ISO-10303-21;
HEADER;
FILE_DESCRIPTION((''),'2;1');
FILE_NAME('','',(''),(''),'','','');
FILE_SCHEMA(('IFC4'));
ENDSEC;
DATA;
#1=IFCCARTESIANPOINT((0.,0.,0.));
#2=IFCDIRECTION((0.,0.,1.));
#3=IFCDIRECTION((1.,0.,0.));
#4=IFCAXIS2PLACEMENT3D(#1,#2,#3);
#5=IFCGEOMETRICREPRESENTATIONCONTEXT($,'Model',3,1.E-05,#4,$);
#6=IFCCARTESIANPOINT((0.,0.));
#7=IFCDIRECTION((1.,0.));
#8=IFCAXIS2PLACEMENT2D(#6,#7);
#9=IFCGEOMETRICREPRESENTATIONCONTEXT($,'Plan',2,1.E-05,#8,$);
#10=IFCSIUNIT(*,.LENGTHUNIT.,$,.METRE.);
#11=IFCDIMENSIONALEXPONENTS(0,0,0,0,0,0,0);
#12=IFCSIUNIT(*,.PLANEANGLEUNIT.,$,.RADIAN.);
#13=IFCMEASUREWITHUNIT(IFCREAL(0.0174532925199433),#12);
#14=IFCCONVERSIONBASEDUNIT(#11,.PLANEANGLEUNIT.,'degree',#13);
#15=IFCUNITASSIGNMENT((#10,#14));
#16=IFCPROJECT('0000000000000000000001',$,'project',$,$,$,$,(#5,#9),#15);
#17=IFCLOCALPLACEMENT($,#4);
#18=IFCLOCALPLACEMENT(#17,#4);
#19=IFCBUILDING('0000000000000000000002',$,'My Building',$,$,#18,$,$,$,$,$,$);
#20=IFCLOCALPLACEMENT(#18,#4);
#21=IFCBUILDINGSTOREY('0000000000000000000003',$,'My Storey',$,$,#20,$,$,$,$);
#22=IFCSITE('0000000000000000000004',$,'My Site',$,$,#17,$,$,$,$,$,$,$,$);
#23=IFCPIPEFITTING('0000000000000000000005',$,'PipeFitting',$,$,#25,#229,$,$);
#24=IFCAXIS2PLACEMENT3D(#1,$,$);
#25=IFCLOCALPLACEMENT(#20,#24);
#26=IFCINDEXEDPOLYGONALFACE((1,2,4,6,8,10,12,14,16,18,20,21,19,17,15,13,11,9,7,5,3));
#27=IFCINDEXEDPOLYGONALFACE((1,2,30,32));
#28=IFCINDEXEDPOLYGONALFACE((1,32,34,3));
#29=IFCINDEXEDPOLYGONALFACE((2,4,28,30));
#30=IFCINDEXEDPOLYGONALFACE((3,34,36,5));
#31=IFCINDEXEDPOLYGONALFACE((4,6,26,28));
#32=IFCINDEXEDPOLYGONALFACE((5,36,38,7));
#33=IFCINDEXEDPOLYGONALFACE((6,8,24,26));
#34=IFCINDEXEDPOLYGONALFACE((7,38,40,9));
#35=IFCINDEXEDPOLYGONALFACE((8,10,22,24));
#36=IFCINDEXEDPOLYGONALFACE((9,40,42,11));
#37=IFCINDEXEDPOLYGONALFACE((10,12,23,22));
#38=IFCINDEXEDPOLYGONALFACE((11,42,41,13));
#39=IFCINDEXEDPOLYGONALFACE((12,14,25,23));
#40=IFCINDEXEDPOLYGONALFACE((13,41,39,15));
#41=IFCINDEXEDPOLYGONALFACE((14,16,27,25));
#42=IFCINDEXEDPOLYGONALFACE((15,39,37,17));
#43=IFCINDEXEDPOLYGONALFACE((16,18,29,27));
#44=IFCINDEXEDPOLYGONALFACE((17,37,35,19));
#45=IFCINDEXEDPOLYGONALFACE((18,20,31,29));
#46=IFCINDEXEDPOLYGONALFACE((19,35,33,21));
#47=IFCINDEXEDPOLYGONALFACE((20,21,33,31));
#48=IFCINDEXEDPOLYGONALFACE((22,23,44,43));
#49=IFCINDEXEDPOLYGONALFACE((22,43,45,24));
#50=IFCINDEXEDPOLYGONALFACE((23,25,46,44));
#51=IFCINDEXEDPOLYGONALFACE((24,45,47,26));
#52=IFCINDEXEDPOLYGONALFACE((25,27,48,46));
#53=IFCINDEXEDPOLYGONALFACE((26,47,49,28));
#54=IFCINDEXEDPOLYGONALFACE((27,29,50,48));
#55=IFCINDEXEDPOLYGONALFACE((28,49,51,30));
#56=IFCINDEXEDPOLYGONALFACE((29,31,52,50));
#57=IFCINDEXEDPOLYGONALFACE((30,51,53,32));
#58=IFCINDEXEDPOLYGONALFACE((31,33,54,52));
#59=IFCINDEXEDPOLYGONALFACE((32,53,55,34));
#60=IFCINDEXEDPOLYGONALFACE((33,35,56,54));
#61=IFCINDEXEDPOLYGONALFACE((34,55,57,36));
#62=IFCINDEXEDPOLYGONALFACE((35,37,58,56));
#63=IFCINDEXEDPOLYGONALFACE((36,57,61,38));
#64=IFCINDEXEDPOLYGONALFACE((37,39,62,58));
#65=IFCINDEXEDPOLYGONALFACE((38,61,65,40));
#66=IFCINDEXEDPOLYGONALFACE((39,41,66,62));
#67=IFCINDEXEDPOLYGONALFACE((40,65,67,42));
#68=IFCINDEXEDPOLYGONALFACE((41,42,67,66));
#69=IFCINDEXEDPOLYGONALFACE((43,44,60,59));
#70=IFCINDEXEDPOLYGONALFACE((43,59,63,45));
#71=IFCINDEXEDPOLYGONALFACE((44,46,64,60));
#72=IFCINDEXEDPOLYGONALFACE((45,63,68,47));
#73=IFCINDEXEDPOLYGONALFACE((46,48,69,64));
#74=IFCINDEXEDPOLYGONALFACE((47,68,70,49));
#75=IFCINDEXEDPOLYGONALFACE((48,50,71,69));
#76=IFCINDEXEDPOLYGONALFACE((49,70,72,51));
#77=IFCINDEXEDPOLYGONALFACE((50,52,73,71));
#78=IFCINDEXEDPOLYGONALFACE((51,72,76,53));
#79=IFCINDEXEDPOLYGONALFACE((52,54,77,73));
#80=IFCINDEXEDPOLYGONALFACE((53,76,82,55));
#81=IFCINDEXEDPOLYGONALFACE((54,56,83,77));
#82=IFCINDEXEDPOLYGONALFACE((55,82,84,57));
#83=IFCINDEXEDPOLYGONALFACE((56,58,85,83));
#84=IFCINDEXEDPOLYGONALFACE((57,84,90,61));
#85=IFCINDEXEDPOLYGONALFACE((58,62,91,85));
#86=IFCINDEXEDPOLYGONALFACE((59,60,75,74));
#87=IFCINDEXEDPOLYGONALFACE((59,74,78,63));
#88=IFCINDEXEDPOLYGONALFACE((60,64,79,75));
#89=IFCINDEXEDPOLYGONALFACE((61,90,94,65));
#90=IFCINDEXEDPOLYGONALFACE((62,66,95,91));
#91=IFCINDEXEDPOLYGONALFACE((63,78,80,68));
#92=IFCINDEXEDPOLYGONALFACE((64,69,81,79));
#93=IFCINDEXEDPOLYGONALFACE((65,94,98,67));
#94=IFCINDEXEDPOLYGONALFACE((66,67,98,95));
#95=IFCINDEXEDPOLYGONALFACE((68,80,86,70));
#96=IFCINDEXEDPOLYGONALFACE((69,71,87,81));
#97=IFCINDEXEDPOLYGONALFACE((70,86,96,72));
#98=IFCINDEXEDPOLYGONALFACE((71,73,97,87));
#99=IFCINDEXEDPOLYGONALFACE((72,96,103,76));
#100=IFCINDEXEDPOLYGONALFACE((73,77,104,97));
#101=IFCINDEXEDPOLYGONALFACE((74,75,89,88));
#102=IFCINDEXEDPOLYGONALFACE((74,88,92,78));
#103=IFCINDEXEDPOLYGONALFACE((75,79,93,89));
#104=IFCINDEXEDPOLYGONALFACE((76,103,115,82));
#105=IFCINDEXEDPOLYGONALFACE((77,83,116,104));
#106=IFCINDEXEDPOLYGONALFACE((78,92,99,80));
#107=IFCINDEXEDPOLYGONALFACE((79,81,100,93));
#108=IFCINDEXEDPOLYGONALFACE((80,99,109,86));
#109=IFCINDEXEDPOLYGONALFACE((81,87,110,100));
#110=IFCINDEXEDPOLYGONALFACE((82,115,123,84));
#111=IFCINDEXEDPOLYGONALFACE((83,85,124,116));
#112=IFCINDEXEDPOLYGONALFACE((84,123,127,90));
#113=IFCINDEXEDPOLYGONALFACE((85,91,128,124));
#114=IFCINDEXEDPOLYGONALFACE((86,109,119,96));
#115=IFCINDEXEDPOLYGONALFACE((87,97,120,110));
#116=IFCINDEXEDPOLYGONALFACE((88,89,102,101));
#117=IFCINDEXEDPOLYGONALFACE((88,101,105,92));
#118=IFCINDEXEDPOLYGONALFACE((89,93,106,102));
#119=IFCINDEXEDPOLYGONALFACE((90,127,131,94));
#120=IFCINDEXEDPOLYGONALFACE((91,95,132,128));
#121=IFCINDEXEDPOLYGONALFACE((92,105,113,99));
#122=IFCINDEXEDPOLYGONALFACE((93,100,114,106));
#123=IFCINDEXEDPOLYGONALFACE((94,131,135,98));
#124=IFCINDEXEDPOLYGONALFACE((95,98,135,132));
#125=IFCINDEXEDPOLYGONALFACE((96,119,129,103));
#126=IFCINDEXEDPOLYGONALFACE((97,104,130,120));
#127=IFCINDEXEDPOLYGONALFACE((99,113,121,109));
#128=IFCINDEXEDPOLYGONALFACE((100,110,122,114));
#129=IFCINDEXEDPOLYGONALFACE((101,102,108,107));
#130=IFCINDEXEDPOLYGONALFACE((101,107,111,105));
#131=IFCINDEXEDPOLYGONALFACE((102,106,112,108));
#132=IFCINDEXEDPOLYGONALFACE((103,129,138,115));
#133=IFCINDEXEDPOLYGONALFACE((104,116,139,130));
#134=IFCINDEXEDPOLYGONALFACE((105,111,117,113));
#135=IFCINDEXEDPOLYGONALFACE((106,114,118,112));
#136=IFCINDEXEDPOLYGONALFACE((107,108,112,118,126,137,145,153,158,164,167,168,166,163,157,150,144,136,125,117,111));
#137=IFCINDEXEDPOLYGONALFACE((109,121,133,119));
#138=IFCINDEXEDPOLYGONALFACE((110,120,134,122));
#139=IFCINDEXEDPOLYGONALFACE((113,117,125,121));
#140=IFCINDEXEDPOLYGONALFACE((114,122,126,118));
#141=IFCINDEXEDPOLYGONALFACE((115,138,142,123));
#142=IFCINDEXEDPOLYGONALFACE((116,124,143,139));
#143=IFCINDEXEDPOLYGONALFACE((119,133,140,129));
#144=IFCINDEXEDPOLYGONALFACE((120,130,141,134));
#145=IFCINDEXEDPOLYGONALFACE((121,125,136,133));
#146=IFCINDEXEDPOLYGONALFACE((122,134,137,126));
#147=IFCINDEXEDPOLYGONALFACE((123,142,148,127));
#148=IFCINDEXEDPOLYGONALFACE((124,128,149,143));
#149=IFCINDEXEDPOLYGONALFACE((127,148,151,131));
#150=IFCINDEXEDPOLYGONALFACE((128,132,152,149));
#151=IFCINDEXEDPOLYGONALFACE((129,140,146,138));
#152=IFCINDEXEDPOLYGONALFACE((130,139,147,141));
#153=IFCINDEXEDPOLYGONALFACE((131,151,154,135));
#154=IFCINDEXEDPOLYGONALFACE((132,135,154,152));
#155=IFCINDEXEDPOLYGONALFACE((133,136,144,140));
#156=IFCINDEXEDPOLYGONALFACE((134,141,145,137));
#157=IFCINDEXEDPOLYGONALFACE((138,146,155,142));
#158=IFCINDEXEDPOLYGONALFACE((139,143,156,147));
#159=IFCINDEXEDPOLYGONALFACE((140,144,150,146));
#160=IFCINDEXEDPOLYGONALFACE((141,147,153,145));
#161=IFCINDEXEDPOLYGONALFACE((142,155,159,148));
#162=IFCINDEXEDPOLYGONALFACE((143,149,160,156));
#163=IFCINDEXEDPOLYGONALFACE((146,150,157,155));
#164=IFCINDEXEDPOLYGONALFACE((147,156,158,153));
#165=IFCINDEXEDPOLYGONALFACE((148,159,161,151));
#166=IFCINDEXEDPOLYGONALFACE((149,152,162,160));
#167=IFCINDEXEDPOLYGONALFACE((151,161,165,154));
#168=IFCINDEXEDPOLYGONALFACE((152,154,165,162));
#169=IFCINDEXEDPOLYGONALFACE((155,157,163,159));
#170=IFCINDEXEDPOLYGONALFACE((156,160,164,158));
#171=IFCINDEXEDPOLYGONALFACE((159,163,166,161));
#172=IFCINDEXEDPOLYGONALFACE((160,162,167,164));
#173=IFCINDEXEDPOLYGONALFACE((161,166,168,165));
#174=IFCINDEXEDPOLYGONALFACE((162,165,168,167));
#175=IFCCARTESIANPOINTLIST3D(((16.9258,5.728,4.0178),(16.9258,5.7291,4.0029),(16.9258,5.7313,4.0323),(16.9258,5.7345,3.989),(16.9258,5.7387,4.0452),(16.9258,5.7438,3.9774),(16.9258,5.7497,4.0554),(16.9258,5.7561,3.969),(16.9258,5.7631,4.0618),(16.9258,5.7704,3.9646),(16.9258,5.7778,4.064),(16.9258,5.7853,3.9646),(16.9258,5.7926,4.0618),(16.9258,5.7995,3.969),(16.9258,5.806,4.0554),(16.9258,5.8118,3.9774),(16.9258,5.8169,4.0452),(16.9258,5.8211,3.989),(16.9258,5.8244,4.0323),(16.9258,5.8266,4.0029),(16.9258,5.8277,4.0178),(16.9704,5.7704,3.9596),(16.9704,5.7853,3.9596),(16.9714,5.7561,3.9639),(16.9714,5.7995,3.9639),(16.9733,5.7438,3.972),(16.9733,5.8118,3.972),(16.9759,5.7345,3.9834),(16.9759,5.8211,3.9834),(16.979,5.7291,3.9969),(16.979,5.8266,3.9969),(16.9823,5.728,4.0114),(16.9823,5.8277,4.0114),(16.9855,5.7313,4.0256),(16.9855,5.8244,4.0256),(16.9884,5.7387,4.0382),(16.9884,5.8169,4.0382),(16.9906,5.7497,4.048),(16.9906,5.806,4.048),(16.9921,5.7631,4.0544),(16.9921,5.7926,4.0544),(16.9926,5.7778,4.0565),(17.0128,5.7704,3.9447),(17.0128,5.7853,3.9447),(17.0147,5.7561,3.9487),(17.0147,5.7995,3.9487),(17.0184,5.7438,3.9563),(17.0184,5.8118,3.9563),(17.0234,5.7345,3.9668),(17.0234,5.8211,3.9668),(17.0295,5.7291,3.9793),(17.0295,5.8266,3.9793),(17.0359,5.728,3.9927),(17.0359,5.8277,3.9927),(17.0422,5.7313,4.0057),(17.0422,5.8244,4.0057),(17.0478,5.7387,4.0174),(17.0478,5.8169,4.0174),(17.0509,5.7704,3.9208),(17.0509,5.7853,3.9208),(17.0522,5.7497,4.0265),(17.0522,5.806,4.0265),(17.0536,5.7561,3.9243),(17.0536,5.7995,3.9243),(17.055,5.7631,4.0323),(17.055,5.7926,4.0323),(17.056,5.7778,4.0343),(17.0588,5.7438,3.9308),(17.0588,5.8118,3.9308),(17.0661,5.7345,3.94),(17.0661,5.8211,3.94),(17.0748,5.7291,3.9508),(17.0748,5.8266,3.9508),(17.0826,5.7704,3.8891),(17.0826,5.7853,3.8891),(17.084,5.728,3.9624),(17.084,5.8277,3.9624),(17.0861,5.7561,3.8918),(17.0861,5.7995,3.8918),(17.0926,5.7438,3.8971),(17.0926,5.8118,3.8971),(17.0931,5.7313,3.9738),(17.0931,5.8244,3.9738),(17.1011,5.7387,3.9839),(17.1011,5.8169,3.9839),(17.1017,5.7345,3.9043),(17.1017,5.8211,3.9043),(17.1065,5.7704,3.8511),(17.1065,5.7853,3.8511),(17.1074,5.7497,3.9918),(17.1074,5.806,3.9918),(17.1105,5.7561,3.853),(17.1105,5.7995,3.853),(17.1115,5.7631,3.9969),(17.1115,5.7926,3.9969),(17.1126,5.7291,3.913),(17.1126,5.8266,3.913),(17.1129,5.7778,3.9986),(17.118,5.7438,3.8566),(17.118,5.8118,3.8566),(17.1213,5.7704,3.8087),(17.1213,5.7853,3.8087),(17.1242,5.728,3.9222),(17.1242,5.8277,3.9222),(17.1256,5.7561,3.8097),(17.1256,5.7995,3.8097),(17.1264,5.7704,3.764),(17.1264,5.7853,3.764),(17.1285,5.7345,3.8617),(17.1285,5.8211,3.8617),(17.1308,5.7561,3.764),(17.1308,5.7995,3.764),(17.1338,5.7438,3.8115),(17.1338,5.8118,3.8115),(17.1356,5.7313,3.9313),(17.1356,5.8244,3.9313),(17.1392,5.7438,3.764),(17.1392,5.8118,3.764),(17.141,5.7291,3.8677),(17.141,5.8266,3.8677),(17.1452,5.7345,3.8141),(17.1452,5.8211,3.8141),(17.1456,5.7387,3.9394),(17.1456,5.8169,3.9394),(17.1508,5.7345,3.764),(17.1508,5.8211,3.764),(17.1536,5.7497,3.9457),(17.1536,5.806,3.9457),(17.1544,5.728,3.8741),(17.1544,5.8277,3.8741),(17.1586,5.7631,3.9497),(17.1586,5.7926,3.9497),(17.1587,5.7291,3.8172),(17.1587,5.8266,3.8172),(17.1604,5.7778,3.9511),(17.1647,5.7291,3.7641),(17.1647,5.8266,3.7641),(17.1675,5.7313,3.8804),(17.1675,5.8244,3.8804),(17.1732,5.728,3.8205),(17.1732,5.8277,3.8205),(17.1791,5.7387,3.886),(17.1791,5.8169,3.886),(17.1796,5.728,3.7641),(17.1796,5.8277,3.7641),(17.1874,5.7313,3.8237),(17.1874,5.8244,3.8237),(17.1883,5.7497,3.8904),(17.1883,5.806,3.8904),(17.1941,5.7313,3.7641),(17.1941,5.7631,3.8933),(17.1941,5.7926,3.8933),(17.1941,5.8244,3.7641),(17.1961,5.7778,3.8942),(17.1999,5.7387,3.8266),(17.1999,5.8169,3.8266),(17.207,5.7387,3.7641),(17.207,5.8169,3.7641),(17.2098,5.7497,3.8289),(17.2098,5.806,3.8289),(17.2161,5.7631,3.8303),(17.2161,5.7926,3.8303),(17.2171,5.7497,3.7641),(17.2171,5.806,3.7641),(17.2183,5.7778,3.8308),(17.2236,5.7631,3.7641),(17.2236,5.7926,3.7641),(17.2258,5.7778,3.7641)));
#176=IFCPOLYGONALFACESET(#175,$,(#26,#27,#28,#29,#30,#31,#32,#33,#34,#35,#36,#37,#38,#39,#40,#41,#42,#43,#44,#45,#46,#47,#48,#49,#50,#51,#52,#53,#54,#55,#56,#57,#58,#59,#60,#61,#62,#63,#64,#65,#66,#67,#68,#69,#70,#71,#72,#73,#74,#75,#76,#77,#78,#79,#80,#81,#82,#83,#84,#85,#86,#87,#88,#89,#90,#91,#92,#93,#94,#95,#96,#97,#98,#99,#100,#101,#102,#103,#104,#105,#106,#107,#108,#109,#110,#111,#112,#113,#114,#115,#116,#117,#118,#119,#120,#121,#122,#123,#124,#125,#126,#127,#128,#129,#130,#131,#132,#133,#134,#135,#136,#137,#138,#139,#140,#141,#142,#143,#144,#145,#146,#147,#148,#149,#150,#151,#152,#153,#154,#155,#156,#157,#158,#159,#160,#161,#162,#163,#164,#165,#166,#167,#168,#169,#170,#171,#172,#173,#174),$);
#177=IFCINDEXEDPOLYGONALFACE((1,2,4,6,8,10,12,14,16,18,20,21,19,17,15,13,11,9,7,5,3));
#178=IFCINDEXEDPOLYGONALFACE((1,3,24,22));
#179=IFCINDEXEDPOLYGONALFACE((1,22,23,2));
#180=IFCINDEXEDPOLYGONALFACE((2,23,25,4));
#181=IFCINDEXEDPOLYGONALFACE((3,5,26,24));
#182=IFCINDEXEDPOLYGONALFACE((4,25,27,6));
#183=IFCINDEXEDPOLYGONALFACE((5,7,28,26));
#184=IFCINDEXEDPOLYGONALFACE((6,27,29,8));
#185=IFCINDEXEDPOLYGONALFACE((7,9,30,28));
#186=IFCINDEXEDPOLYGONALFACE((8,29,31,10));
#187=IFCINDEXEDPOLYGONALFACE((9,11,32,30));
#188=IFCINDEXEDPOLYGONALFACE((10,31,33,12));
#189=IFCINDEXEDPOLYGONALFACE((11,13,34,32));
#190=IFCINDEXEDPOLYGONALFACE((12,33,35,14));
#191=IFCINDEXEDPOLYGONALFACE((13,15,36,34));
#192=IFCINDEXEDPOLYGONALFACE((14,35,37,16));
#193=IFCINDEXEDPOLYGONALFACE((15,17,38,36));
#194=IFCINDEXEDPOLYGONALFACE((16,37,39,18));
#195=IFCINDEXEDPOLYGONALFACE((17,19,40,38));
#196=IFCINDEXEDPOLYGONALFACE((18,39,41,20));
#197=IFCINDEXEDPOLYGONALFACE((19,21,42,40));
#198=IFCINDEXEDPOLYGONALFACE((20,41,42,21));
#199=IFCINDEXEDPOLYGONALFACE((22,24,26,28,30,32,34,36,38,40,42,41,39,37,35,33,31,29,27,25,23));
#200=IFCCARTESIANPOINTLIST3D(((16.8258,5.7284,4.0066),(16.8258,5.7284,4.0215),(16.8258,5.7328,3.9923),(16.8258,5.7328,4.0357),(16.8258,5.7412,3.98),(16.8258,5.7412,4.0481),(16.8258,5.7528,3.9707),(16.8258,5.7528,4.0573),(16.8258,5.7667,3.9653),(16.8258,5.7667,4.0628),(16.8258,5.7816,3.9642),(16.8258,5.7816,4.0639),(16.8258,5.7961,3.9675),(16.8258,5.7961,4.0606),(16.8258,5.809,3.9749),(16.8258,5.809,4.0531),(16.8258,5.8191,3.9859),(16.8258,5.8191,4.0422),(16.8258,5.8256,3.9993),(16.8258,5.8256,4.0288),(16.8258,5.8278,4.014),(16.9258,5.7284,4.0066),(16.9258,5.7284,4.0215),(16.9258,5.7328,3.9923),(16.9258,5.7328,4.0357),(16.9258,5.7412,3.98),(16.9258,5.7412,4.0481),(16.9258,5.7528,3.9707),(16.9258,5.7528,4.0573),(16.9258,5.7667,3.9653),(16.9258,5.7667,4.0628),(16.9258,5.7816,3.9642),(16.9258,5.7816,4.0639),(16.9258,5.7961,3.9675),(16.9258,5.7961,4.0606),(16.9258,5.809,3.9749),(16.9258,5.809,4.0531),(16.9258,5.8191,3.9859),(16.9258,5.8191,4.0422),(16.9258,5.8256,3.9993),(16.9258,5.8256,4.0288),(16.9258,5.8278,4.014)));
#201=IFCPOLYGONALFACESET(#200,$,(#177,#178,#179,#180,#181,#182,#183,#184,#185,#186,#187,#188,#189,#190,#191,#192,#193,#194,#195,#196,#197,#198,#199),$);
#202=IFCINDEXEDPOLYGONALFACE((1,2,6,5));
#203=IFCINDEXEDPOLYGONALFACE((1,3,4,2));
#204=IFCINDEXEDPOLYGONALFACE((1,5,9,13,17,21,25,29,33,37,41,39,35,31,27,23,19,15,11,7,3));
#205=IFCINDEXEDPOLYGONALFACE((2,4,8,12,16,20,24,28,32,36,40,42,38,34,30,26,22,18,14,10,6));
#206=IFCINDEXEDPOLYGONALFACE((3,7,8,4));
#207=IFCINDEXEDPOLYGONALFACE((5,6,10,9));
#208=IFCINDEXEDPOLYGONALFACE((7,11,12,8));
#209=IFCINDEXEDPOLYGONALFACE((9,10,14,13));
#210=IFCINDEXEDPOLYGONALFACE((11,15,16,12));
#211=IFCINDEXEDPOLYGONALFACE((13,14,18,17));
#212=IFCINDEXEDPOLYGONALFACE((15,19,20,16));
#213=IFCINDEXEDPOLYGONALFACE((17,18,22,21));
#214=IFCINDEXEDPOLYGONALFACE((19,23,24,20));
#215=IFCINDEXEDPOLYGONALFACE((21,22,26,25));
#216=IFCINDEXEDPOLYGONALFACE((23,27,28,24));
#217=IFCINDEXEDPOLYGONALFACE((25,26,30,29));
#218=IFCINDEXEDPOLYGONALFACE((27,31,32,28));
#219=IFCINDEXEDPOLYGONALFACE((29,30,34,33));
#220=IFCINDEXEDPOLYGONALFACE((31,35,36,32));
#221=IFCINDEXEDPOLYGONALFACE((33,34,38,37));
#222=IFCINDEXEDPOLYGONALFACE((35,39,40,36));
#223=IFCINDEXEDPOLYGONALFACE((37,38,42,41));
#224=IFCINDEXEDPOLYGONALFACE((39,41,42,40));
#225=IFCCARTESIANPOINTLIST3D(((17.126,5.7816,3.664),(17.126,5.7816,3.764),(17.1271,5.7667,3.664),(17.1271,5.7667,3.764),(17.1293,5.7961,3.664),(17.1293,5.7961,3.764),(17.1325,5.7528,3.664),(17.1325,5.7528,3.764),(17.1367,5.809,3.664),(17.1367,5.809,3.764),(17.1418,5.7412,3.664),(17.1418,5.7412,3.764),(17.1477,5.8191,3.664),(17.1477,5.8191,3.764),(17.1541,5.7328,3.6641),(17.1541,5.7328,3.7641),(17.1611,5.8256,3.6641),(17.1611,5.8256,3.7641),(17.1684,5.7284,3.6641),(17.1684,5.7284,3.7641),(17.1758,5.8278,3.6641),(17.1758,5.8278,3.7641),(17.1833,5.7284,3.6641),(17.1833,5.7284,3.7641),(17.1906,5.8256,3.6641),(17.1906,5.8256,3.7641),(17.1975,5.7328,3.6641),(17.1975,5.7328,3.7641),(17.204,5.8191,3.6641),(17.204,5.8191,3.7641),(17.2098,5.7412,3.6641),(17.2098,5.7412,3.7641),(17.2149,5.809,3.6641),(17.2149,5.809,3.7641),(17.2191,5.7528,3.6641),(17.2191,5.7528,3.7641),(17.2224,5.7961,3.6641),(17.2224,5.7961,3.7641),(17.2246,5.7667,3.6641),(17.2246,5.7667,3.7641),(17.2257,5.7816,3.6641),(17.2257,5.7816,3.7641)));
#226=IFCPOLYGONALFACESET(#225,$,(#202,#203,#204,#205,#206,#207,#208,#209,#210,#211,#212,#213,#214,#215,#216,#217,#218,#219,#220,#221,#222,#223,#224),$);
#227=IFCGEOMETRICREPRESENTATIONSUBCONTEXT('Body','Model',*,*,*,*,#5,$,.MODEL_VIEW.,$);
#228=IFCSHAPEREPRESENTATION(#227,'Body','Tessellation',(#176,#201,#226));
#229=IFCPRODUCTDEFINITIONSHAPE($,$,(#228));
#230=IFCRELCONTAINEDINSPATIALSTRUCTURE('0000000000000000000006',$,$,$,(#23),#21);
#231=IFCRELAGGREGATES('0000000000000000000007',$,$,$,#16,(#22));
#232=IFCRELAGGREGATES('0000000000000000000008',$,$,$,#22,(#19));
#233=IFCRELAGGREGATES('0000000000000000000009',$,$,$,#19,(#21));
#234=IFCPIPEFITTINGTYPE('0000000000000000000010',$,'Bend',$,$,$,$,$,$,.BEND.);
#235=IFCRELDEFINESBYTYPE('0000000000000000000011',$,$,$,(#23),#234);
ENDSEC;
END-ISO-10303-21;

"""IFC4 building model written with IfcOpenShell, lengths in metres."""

from ifc_helpers import new_model, entity, si_unit, converted_unit, frame, origin_with_axes, origin_2d_with_axis, place, context, subcontext, project, spatial, circle, extrude, source, transform, mapped, type_object, type_shapes, element, save


model = new_model("IFC4")

# Units and contexts
model_context = context("Model", 3, precision=1e-05, world=origin_with_axes())
plan_context = context("Plan", 2, precision=1e-05, world=origin_2d_with_axis())
body_context_1 = subcontext(model_context, "Body", "Model", "MODEL_VIEW")
ifc_project = project(units=[si_unit("LENGTHUNIT", "METRE"), converted_unit("PLANEANGLEUNIT", "degree", entity("IfcReal", 0.0174532925199433), si_unit("PLANEANGLEUNIT", "RADIAN"), dimensions=[0, 0, 0, 0, 0, 0, 0])], contexts=[model_context, plan_context])

# Site, building, storey
site_placement = place(None, origin_with_axes())
site = spatial("IfcSite", under=ifc_project, at=site_placement, Name="My Site")
building_placement = place(site_placement, origin_with_axes())
building = spatial("IfcBuilding", under=site, at=building_placement, Name="My Building")
storey_placement = place(building_placement, origin_with_axes())
storey = spatial("IfcBuildingStorey", under=building, at=storey_placement, Name="My Storey")

# Pipe fitting
pipe_fitting_type_1 = type_object("IfcPipeFittingType", Name="Bend", PredefinedType="BEND")
shared_shape_1 = source(origin_with_axes(), body_context_1, "Body", "SolidModel", [
    entity("IfcSweptDiskSolid", entity("IfcIndexedPolyCurve", entity("IfcCartesianPointList3D", [[0.0, 0.0, 0.1], [0.0, -0.0732, 0.2768], [0.0, -0.25, 0.35]]), [entity("IfcArcIndex", [1, 2, 3])]), 0.05),
    extrude(circle(Radius=0.05), origin_with_axes(), (0.0, 0.0, 1.0), 0.1),
    extrude(circle(Radius=0.05), frame((0.0, -0.25, 0.35), z_axis=(0.0, -1.0, 0.000038), x_axis=(1.0, 0.0, 0.0)), (0.0, 0.0, 1.0), 0.1),
])
type_shapes(pipe_fitting_type_1, [shared_shape_1])
for number, where, z_axis, x_axis, name in (
    (1, (16.8258, 5.7778, 4.014), (1.0, 0.0, 0.0), (0.0, 1.0, 0.0), "PipeFitting"),
):
    element("IfcPipeFitting", number, at=place(storey_placement, frame(where, z_axis=z_axis, x_axis=x_axis)), inside=storey, type_object=pipe_fitting_type_1, Name=name, context=body_context_1, shape_type="MappedRepresentation", body=[
        mapped(shared_shape_1, transform((0.0, 0.0, 0.0), x_axis=(1.0, 0.0, 0.0), y_axis=(0.0, 1.0, 0.0), z_axis=(0.0, 0.0, 1.0), scale=1.0)),
    ])

save(model, "model.ifc")
